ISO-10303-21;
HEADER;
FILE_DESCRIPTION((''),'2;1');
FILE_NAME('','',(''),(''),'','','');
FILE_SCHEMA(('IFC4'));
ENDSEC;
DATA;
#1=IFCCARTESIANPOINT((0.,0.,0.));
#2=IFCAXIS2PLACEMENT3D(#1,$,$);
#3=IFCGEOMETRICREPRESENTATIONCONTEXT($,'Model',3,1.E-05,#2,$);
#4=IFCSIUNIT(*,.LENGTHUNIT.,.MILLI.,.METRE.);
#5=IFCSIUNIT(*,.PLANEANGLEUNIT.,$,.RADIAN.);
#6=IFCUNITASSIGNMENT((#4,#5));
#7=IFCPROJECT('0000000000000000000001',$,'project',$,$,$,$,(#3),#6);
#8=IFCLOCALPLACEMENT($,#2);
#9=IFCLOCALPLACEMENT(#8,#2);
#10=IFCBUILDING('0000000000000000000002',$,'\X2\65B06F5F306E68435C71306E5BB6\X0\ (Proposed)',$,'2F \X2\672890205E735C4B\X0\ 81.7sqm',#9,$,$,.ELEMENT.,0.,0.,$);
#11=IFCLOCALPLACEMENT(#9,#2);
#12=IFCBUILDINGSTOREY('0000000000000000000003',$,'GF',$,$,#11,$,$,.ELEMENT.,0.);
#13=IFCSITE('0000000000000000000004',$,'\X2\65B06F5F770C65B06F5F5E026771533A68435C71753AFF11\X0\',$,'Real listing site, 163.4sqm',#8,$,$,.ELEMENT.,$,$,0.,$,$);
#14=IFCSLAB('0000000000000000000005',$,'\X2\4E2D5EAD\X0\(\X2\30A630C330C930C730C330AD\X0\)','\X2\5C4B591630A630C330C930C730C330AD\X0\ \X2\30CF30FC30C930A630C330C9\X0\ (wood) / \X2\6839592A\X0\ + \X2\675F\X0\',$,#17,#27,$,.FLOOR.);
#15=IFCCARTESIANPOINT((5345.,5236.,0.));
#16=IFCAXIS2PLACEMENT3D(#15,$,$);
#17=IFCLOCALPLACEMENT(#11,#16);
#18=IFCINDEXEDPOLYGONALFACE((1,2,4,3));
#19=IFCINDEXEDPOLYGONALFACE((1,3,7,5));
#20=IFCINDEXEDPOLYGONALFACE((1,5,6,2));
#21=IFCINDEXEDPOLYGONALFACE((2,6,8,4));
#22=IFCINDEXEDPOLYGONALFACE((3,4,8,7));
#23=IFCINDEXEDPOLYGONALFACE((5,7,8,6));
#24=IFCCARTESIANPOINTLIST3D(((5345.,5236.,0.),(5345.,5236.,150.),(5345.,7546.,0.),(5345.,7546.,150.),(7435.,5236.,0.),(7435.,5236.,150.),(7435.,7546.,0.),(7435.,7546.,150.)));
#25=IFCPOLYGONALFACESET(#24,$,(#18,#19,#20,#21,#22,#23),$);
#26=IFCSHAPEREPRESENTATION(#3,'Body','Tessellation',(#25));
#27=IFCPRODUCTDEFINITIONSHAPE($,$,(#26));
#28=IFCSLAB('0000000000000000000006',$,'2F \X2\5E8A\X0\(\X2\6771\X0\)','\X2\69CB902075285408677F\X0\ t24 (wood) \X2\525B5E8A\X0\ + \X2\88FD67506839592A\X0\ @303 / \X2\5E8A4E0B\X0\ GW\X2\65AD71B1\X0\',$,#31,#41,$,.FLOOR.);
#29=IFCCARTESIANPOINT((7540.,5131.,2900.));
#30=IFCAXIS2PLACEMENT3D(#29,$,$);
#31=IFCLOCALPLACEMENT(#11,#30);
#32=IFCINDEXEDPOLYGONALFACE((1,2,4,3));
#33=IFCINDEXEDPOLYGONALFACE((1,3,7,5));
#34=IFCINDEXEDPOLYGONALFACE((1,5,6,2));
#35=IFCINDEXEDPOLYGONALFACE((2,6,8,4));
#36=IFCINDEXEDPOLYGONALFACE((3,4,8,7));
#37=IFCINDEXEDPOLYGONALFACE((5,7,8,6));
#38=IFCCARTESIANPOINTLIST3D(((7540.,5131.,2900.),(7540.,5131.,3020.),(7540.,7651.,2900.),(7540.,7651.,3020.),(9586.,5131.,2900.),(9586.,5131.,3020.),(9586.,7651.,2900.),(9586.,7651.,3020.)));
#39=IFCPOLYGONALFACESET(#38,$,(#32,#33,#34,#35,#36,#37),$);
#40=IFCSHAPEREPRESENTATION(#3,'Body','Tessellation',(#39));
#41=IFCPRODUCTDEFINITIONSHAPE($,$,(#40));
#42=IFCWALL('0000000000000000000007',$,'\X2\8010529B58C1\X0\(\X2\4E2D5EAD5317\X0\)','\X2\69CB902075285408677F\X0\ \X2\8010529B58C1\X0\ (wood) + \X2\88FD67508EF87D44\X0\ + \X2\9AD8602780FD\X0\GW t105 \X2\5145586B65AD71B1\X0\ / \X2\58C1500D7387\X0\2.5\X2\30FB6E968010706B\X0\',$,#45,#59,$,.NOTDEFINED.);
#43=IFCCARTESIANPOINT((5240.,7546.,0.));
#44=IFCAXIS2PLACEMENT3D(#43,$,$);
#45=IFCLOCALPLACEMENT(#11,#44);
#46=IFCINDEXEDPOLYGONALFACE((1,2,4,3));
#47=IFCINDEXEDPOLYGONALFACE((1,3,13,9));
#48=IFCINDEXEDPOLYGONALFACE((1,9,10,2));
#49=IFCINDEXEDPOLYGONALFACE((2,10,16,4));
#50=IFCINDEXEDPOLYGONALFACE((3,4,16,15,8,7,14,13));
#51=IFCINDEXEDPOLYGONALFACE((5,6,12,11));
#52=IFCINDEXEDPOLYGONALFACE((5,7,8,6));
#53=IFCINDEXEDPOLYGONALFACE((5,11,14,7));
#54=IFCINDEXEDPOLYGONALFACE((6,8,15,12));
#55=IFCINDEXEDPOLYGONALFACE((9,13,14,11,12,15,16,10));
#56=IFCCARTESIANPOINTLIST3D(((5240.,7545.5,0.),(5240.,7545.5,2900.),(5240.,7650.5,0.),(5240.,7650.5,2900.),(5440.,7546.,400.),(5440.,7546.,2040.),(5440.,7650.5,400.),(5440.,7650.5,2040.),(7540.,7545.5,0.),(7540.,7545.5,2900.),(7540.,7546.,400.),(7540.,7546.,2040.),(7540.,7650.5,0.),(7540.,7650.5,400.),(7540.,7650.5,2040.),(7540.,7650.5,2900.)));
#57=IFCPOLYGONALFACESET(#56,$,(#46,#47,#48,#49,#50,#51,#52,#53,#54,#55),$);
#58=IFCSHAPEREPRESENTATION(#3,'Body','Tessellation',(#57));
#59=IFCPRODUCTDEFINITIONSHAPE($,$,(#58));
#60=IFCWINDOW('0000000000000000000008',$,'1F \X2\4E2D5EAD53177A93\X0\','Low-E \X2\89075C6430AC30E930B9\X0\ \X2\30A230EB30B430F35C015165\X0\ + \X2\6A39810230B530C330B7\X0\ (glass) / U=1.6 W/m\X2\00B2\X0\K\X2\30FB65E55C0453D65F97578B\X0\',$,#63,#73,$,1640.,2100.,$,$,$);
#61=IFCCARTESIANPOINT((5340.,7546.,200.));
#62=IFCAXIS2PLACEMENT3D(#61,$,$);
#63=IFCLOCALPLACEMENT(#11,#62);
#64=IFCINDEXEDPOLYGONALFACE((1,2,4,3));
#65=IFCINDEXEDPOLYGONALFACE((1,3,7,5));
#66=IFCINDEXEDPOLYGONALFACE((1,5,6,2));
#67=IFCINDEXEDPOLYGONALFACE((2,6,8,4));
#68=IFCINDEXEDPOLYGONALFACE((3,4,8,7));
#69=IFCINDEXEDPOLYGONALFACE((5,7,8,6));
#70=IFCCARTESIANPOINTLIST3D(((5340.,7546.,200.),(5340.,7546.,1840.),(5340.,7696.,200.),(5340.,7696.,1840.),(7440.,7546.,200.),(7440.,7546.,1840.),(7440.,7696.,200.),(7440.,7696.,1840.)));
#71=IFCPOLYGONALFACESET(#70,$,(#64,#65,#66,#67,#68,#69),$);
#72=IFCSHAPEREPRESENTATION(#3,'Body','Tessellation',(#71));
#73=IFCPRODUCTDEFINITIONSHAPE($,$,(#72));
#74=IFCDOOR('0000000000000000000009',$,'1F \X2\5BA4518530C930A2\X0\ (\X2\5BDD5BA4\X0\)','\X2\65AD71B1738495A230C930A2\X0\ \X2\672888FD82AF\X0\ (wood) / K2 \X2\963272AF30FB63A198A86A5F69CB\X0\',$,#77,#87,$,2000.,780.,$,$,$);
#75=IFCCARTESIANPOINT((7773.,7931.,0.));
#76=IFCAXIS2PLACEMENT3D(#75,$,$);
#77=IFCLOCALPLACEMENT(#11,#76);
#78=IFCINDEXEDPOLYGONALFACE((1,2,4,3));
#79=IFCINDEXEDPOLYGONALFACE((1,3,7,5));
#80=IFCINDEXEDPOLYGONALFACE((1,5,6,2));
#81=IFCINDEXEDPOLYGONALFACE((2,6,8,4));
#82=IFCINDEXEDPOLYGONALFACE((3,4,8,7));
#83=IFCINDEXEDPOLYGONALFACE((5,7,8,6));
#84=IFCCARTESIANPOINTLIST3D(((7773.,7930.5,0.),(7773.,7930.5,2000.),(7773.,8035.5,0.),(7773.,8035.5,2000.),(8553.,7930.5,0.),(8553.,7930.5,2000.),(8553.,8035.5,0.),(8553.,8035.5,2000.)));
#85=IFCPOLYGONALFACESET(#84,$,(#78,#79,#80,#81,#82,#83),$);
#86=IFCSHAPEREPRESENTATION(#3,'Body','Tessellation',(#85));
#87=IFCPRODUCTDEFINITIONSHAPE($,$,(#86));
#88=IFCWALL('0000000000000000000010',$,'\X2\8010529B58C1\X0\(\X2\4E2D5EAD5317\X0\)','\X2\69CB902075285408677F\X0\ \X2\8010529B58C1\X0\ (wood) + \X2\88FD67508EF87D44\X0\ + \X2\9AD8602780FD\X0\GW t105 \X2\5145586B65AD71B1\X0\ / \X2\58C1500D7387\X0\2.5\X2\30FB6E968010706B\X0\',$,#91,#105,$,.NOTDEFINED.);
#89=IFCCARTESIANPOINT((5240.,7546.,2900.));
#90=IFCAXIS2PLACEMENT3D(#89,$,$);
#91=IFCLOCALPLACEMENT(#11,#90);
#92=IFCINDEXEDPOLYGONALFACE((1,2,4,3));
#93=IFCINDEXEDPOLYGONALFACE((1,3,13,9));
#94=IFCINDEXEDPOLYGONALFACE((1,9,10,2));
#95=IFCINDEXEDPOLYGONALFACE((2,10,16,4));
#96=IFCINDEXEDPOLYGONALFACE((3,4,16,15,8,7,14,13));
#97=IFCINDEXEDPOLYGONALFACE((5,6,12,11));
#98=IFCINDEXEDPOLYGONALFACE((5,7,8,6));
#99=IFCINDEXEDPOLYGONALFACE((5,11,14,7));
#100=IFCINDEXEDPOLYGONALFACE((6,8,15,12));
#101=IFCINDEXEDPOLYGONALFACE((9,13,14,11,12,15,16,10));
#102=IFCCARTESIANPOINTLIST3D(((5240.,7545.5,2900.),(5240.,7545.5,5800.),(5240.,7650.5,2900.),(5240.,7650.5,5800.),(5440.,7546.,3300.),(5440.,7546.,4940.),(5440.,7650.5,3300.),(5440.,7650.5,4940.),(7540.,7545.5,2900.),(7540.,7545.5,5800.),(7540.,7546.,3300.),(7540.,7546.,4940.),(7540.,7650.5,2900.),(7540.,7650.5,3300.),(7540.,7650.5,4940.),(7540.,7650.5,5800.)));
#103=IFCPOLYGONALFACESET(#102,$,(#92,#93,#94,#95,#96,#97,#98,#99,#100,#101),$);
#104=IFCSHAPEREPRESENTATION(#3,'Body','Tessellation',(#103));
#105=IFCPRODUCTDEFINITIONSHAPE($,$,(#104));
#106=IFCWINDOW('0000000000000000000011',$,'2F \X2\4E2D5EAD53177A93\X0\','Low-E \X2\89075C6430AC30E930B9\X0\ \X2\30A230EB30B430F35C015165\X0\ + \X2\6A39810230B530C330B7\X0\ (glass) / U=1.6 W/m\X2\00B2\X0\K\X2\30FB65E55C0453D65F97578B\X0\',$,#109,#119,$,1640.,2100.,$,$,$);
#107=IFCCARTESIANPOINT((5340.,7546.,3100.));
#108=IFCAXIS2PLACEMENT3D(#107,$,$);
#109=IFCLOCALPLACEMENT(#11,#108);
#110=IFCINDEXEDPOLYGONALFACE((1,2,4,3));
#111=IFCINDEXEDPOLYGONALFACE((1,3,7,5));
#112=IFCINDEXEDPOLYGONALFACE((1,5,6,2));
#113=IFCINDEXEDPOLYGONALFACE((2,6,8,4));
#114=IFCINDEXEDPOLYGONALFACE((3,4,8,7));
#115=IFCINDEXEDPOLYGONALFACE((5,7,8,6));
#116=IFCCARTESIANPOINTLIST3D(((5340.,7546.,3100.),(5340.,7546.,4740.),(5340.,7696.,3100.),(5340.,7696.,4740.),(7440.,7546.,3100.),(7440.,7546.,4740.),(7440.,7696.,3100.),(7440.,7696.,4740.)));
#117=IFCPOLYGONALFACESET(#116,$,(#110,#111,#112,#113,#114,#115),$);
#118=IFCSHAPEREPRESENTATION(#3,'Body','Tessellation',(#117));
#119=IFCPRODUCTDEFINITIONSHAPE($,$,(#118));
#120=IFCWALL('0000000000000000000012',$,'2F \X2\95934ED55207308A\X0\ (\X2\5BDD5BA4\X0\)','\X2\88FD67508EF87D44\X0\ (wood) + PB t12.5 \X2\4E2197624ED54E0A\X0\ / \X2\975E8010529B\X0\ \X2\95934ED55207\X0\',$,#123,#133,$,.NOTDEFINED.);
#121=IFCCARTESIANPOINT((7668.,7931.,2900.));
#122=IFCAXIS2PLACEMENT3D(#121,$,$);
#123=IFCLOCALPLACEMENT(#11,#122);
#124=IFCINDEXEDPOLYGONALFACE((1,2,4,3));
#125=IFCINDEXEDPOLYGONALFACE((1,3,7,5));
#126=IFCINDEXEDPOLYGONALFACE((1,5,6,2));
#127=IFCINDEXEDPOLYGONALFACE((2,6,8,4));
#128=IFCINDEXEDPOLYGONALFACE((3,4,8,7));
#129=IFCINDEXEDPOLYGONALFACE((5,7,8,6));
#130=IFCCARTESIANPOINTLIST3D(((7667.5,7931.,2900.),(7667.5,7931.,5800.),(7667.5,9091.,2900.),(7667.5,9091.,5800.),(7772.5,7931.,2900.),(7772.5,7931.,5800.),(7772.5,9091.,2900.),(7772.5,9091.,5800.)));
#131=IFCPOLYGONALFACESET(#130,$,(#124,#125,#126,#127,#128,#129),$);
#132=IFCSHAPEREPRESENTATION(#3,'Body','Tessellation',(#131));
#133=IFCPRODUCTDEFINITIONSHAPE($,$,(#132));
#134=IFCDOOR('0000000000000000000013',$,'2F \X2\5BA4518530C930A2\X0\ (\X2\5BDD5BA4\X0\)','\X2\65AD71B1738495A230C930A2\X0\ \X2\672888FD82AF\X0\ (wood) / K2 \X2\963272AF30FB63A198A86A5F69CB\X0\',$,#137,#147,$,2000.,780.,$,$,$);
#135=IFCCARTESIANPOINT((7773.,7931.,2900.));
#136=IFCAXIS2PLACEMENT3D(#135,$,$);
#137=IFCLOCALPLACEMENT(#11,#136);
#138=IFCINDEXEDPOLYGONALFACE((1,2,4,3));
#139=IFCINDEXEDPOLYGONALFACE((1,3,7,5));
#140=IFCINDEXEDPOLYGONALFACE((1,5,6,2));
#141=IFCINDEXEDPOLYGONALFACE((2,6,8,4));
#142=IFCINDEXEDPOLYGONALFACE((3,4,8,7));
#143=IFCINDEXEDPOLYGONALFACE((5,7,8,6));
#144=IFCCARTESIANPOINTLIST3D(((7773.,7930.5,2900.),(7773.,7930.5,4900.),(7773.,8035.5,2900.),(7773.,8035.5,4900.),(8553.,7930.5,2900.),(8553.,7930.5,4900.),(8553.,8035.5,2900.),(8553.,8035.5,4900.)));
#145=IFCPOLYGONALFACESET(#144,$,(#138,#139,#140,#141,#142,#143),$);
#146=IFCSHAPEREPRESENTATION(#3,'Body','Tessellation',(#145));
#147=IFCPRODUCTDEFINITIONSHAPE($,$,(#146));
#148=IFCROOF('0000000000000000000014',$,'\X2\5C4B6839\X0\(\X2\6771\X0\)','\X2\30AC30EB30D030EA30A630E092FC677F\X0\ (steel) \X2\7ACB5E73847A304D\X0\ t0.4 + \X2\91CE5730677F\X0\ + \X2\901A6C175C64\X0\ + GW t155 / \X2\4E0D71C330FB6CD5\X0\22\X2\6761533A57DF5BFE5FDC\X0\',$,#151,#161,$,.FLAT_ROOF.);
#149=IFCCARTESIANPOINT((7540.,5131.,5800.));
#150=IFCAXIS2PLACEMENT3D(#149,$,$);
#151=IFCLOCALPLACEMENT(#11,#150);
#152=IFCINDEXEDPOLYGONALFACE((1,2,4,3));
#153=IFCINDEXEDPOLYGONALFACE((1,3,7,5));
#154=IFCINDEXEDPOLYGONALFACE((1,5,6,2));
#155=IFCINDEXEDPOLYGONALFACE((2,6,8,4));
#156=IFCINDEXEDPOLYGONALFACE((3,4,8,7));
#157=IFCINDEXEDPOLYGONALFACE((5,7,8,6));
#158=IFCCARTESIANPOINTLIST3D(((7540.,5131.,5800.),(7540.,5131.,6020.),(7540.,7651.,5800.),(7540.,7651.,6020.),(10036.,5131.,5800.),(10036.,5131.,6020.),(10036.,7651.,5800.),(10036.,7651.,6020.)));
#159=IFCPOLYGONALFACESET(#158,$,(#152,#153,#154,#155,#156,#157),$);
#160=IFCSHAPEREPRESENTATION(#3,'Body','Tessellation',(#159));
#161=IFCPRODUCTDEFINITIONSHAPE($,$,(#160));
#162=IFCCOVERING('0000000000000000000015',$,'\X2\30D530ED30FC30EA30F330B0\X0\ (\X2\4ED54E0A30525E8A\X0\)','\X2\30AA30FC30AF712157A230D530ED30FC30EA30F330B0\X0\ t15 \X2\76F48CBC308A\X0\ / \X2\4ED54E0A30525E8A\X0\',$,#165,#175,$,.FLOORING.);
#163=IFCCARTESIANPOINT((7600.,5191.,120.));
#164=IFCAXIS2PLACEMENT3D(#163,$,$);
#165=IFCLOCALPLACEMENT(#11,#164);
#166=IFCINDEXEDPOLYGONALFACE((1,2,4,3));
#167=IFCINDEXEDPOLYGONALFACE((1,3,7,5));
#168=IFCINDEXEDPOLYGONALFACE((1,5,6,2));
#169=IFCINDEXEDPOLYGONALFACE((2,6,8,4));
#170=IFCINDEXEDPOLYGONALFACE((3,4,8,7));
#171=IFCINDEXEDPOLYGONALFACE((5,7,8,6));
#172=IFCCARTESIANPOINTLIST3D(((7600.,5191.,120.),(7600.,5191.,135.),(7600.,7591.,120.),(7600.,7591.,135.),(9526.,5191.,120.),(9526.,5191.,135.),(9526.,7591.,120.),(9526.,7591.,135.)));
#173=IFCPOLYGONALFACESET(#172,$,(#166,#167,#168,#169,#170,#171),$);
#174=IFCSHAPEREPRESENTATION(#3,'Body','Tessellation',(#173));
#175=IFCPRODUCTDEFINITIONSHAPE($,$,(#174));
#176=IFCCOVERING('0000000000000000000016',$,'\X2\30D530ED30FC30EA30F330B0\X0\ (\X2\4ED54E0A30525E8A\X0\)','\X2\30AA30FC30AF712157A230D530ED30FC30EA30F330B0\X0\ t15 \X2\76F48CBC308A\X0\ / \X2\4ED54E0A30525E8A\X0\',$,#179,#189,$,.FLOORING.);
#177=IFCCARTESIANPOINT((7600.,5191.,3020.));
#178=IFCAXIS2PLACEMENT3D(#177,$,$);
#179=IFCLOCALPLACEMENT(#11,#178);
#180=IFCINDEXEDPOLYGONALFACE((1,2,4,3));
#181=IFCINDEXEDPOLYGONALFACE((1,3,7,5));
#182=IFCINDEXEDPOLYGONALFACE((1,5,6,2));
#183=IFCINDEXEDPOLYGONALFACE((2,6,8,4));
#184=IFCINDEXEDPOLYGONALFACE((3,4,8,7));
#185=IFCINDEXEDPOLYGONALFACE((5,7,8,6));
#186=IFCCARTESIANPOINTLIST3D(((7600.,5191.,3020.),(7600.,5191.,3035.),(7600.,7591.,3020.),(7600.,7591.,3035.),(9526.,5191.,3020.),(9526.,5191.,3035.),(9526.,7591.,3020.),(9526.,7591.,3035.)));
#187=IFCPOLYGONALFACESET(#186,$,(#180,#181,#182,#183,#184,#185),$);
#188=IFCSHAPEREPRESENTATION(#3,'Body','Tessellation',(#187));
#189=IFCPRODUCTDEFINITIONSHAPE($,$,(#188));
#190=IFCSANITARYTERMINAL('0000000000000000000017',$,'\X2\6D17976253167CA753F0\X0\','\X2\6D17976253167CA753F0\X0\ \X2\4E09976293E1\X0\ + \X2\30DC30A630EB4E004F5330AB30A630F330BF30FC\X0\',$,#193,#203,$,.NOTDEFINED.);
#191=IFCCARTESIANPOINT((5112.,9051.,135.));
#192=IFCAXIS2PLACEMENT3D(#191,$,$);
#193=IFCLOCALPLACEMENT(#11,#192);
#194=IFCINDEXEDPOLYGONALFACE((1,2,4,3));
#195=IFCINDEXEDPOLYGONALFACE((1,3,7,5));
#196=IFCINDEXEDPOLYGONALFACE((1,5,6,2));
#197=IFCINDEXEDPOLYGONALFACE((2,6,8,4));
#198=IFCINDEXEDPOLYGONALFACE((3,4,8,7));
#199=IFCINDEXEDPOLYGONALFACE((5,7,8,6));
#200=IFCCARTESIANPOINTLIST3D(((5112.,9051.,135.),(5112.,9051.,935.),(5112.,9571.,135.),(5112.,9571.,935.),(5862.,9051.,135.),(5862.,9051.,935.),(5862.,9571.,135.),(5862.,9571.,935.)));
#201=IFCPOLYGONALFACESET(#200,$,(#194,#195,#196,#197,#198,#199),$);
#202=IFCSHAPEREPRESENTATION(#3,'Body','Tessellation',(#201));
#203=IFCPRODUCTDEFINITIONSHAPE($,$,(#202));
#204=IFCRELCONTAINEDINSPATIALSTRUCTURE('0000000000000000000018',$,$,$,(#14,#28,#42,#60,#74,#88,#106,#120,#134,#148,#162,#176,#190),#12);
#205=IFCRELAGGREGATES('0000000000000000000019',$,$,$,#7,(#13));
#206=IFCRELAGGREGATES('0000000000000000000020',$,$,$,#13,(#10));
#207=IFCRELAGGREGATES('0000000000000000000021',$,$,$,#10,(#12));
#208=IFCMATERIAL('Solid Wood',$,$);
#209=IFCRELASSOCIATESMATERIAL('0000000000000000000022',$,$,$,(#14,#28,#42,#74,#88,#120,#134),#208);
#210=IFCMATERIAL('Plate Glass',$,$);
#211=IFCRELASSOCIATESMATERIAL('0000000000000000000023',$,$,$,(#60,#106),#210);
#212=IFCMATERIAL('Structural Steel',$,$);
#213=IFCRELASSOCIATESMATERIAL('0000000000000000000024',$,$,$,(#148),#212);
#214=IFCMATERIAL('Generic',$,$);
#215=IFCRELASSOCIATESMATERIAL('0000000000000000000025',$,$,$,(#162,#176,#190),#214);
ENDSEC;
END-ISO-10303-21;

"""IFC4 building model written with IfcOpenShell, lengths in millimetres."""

from ifc_helpers import new_model, si_unit, frame, frame_2d, origin, place, context, project, spatial, rectangle, extrude, material, element, fill, save


model = new_model("IFC4")

# Units and contexts
model_context = context("Model", 3, precision=1e-05, world=origin())
ifc_project = project(units=[si_unit("LENGTHUNIT", "METRE", prefix="MILLI"), si_unit("PLANEANGLEUNIT", "RADIAN")], contexts=[model_context])

# Site, building, storey
site_placement = place(None, origin())
site = spatial("IfcSite", under=ifc_project, at=site_placement, Name="新潟県新潟市東区桃山町１", ObjectType="Real listing site, 163.4sqm", CompositionType="ELEMENT", RefElevation=0.0)
building_placement = place(site_placement, origin())
building = spatial("IfcBuilding", under=site, at=building_placement, Name="新潟の桃山の家 (Proposed)", ObjectType="2F 木造平屋 81.7sqm", CompositionType="ELEMENT", ElevationOfRefHeight=0.0, ElevationOfTerrain=0.0)
storey_placement = place(building_placement, origin())
storey = spatial("IfcBuildingStorey", under=building, at=storey_placement, Name="GF", CompositionType="ELEMENT", Elevation=0.0)

# Slabs
ifc_material_1 = material(Name="Solid Wood")
slab_1_placement = place(storey_placement, frame((5345.0, 5236.0, 0.0)))
element("IfcSlab", 1, at=slab_1_placement, inside=storey, material=ifc_material_1, Name="中庭(ウッドデッキ)", Description="屋外ウッドデッキ ハードウッド (wood) / 根太 + 束", PredefinedType="FLOOR", context=model_context, shape_type="SweptSolid", body=[
    extrude(rectangle(XDim=2090.0, YDim=2310.0, at=frame_2d((1045.0, 1155.0))), frame((5345.0, 5236.0, 0.0)), (0.0, 0.0, 1.0), 150.0),
])
slab_2_placement = place(storey_placement, frame((7540.0, 5131.0, 2900.0)))
element("IfcSlab", 2, at=slab_2_placement, inside=storey, material=ifc_material_1, Name="2F 床(東)", Description="構造用合板 t24 (wood) 剛床 + 製材根太 @303 / 床下 GW断熱", PredefinedType="FLOOR", context=model_context, shape_type="SweptSolid", body=[
    extrude(rectangle(XDim=2046.0, YDim=2520.0, at=frame_2d((1023.0, 1260.0))), frame((7540.0, 5131.0, 2900.0)), (0.0, 0.0, 1.0), 120.0),
])

# Wall, opening, window
wall_1_placement = place(storey_placement, frame((5240.0, 7546.0, 0.0)))
wall_1 = element("IfcWall", 3, at=wall_1_placement, inside=storey, material=ifc_material_1, Name="耐力壁(中庭北)", Description="構造用合板 耐力壁 (wood) + 製材軸組 + 高性能GW t105 充填断熱 / 壁倍率2.5・準耐火", PredefinedType="NOTDEFINED", context=model_context, shape_type="SweptSolid", body=[
    extrude(rectangle(XDim=2300.0, YDim=105.0, at=frame_2d((1150.0, 52.0))), frame((5240.0, 7546.0, 0.0)), (0.0, 0.0, 1.0), 2900.0),
])
opening_1_placement = place(storey_placement, frame((5340.0, 7546.0, 200.0)))
opening_1 = element("IfcOpeningElement", 4, at=opening_1_placement, cuts=wall_1, PredefinedType="NOTDEFINED", context=model_context, shape_type="SweptSolid", body=[
    extrude(rectangle(XDim=2100.0, YDim=150.0, at=frame_2d((1050.0, 75.0))), frame((5340.0, 7546.0, 200.0)), (0.0, 0.0, 1.0), 1640.0),
])
ifc_material_2 = material(Name="Plate Glass")
window_1_placement = place(storey_placement, frame((5340.0, 7546.0, 200.0)))
window_1 = element("IfcWindow", 5, at=window_1_placement, inside=storey, material=ifc_material_2, Name="1F 中庭北窓", Description="Low-E 複層ガラス アルゴン封入 + 樹脂サッシ (glass) / U=1.6 W/m²K・日射取得型", OverallHeight=1640.0, OverallWidth=2100.0, context=model_context, shape_type="SweptSolid", body=[
    extrude(rectangle(XDim=2100.0, YDim=150.0, at=frame_2d((1050.0, 75.0))), frame((5340.0, 7546.0, 200.0)), (0.0, 0.0, 1.0), 1640.0),
])
fill(opening_1, window_1)

# Door
door_1_placement = place(storey_placement, frame((7773.0, 7931.0, 0.0)))
element("IfcDoor", 6, at=door_1_placement, inside=storey, material=ifc_material_1, Name="1F 室内ドア (寝室)", Description="断熱玄関ドア 木製芯 (wood) / K2 防犯・採風機構", OverallHeight=2000.0, OverallWidth=780.0, context=model_context, shape_type="SweptSolid", body=[
    extrude(rectangle(XDim=780.0, YDim=105.0, at=frame_2d((390.0, 52.0))), frame((7773.0, 7931.0, 0.0)), (0.0, 0.0, 1.0), 2000.0),
])

# Wall, opening, window
wall_2_placement = place(storey_placement, frame((5240.0, 7546.0, 2900.0)))
wall_2 = element("IfcWall", 7, at=wall_2_placement, inside=storey, material=ifc_material_1, Name="耐力壁(中庭北)", Description="構造用合板 耐力壁 (wood) + 製材軸組 + 高性能GW t105 充填断熱 / 壁倍率2.5・準耐火", PredefinedType="NOTDEFINED", context=model_context, shape_type="SweptSolid", body=[
    extrude(rectangle(XDim=2300.0, YDim=105.0, at=frame_2d((1150.0, 52.0))), frame((5240.0, 7546.0, 2900.0)), (0.0, 0.0, 1.0), 2900.0),
])
opening_2_placement = place(storey_placement, frame((5340.0, 7546.0, 3100.0)))
opening_2 = element("IfcOpeningElement", 8, at=opening_2_placement, cuts=wall_2, PredefinedType="NOTDEFINED", context=model_context, shape_type="SweptSolid", body=[
    extrude(rectangle(XDim=2100.0, YDim=150.0, at=frame_2d((1050.0, 75.0))), frame((5340.0, 7546.0, 3100.0)), (0.0, 0.0, 1.0), 1640.0),
])
window_2_placement = place(storey_placement, frame((5340.0, 7546.0, 3100.0)))
window_2 = element("IfcWindow", 9, at=window_2_placement, inside=storey, material=ifc_material_2, Name="2F 中庭北窓", Description="Low-E 複層ガラス アルゴン封入 + 樹脂サッシ (glass) / U=1.6 W/m²K・日射取得型", OverallHeight=1640.0, OverallWidth=2100.0, context=model_context, shape_type="SweptSolid", body=[
    extrude(rectangle(XDim=2100.0, YDim=150.0, at=frame_2d((1050.0, 75.0))), frame((5340.0, 7546.0, 3100.0)), (0.0, 0.0, 1.0), 1640.0),
])
fill(opening_2, window_2)

# Wall
wall_3_placement = place(storey_placement, frame((7668.0, 7931.0, 2900.0)))
element("IfcWall", 10, at=wall_3_placement, inside=storey, material=ifc_material_1, Name="2F 間仕切り (寝室)", Description="製材軸組 (wood) + PB t12.5 両面仕上 / 非耐力 間仕切", PredefinedType="NOTDEFINED", context=model_context, shape_type="SweptSolid", body=[
    extrude(rectangle(XDim=105.0, YDim=1160.0, at=frame_2d((52.0, 580.0))), frame((7668.0, 7931.0, 2900.0)), (0.0, 0.0, 1.0), 2900.0),
])

# Door
door_2_placement = place(storey_placement, frame((7773.0, 7931.0, 2900.0)))
element("IfcDoor", 11, at=door_2_placement, inside=storey, material=ifc_material_1, Name="2F 室内ドア (寝室)", Description="断熱玄関ドア 木製芯 (wood) / K2 防犯・採風機構", OverallHeight=2000.0, OverallWidth=780.0, context=model_context, shape_type="SweptSolid", body=[
    extrude(rectangle(XDim=780.0, YDim=105.0, at=frame_2d((390.0, 52.0))), frame((7773.0, 7931.0, 2900.0)), (0.0, 0.0, 1.0), 2000.0),
])

# Roof
ifc_material_3 = material(Name="Structural Steel")
for number, where, name in (
    (12, (7540.0, 5131.0, 5800.0), "屋根(東)"),
):
    element("IfcRoof", number, at=place(storey_placement, frame(where)), inside=storey, material=ifc_material_3, Name=name, Description="ガルバリウム鋼板 (steel) 立平葺き t0.4 + 野地板 + 通気層 + GW t155 / 不燃・法22条区域対応", PredefinedType="FLAT_ROOF", context=model_context, shape_type="SweptSolid", body=[
        extrude(rectangle(XDim=2496.0, YDim=2520.0, at=frame_2d((1248.0, 1260.0))), frame((7540.0, 5131.0, 5800.0)), (0.0, 0.0, 1.0), 220.0),
    ])

# Coverings
ifc_material_4 = material(Name="Generic")
covering_1_placement = place(storey_placement, frame((7600.0, 5191.0, 120.0)))
element("IfcCovering", 13, at=covering_1_placement, inside=storey, material=ifc_material_4, Name="フローリング (仕上げ床)", Description="オーク無垢フローリング t15 直貼り / 仕上げ床", PredefinedType="FLOORING", context=model_context, shape_type="SweptSolid", body=[
    extrude(rectangle(XDim=1926.0, YDim=2400.0, at=frame_2d((963.0, 1200.0))), frame((7600.0, 5191.0, 120.0)), (0.0, 0.0, 1.0), 15.0),
])
covering_2_placement = place(storey_placement, frame((7600.0, 5191.0, 3020.0)))
element("IfcCovering", 14, at=covering_2_placement, inside=storey, material=ifc_material_4, Name="フローリング (仕上げ床)", Description="オーク無垢フローリング t15 直貼り / 仕上げ床", PredefinedType="FLOORING", context=model_context, shape_type="SweptSolid", body=[
    extrude(rectangle(XDim=1926.0, YDim=2400.0, at=frame_2d((963.0, 1200.0))), frame((7600.0, 5191.0, 3020.0)), (0.0, 0.0, 1.0), 15.0),
])

# Sanitary terminal
sanitary_terminal_1_placement = place(storey_placement, frame((5112.0, 9051.0, 135.0)))
element("IfcSanitaryTerminal", 15, at=sanitary_terminal_1_placement, inside=storey, material=ifc_material_4, Name="洗面化粧台", Description="洗面化粧台 三面鏡 + ボウル一体カウンター", PredefinedType="NOTDEFINED", context=model_context, shape_type="SweptSolid", body=[
    extrude(rectangle(XDim=750.0, YDim=520.0, at=frame_2d((375.0, 260.0))), frame((5112.0, 9051.0, 135.0)), (0.0, 0.0, 1.0), 800.0),
])

save(model, "model.ifc")
